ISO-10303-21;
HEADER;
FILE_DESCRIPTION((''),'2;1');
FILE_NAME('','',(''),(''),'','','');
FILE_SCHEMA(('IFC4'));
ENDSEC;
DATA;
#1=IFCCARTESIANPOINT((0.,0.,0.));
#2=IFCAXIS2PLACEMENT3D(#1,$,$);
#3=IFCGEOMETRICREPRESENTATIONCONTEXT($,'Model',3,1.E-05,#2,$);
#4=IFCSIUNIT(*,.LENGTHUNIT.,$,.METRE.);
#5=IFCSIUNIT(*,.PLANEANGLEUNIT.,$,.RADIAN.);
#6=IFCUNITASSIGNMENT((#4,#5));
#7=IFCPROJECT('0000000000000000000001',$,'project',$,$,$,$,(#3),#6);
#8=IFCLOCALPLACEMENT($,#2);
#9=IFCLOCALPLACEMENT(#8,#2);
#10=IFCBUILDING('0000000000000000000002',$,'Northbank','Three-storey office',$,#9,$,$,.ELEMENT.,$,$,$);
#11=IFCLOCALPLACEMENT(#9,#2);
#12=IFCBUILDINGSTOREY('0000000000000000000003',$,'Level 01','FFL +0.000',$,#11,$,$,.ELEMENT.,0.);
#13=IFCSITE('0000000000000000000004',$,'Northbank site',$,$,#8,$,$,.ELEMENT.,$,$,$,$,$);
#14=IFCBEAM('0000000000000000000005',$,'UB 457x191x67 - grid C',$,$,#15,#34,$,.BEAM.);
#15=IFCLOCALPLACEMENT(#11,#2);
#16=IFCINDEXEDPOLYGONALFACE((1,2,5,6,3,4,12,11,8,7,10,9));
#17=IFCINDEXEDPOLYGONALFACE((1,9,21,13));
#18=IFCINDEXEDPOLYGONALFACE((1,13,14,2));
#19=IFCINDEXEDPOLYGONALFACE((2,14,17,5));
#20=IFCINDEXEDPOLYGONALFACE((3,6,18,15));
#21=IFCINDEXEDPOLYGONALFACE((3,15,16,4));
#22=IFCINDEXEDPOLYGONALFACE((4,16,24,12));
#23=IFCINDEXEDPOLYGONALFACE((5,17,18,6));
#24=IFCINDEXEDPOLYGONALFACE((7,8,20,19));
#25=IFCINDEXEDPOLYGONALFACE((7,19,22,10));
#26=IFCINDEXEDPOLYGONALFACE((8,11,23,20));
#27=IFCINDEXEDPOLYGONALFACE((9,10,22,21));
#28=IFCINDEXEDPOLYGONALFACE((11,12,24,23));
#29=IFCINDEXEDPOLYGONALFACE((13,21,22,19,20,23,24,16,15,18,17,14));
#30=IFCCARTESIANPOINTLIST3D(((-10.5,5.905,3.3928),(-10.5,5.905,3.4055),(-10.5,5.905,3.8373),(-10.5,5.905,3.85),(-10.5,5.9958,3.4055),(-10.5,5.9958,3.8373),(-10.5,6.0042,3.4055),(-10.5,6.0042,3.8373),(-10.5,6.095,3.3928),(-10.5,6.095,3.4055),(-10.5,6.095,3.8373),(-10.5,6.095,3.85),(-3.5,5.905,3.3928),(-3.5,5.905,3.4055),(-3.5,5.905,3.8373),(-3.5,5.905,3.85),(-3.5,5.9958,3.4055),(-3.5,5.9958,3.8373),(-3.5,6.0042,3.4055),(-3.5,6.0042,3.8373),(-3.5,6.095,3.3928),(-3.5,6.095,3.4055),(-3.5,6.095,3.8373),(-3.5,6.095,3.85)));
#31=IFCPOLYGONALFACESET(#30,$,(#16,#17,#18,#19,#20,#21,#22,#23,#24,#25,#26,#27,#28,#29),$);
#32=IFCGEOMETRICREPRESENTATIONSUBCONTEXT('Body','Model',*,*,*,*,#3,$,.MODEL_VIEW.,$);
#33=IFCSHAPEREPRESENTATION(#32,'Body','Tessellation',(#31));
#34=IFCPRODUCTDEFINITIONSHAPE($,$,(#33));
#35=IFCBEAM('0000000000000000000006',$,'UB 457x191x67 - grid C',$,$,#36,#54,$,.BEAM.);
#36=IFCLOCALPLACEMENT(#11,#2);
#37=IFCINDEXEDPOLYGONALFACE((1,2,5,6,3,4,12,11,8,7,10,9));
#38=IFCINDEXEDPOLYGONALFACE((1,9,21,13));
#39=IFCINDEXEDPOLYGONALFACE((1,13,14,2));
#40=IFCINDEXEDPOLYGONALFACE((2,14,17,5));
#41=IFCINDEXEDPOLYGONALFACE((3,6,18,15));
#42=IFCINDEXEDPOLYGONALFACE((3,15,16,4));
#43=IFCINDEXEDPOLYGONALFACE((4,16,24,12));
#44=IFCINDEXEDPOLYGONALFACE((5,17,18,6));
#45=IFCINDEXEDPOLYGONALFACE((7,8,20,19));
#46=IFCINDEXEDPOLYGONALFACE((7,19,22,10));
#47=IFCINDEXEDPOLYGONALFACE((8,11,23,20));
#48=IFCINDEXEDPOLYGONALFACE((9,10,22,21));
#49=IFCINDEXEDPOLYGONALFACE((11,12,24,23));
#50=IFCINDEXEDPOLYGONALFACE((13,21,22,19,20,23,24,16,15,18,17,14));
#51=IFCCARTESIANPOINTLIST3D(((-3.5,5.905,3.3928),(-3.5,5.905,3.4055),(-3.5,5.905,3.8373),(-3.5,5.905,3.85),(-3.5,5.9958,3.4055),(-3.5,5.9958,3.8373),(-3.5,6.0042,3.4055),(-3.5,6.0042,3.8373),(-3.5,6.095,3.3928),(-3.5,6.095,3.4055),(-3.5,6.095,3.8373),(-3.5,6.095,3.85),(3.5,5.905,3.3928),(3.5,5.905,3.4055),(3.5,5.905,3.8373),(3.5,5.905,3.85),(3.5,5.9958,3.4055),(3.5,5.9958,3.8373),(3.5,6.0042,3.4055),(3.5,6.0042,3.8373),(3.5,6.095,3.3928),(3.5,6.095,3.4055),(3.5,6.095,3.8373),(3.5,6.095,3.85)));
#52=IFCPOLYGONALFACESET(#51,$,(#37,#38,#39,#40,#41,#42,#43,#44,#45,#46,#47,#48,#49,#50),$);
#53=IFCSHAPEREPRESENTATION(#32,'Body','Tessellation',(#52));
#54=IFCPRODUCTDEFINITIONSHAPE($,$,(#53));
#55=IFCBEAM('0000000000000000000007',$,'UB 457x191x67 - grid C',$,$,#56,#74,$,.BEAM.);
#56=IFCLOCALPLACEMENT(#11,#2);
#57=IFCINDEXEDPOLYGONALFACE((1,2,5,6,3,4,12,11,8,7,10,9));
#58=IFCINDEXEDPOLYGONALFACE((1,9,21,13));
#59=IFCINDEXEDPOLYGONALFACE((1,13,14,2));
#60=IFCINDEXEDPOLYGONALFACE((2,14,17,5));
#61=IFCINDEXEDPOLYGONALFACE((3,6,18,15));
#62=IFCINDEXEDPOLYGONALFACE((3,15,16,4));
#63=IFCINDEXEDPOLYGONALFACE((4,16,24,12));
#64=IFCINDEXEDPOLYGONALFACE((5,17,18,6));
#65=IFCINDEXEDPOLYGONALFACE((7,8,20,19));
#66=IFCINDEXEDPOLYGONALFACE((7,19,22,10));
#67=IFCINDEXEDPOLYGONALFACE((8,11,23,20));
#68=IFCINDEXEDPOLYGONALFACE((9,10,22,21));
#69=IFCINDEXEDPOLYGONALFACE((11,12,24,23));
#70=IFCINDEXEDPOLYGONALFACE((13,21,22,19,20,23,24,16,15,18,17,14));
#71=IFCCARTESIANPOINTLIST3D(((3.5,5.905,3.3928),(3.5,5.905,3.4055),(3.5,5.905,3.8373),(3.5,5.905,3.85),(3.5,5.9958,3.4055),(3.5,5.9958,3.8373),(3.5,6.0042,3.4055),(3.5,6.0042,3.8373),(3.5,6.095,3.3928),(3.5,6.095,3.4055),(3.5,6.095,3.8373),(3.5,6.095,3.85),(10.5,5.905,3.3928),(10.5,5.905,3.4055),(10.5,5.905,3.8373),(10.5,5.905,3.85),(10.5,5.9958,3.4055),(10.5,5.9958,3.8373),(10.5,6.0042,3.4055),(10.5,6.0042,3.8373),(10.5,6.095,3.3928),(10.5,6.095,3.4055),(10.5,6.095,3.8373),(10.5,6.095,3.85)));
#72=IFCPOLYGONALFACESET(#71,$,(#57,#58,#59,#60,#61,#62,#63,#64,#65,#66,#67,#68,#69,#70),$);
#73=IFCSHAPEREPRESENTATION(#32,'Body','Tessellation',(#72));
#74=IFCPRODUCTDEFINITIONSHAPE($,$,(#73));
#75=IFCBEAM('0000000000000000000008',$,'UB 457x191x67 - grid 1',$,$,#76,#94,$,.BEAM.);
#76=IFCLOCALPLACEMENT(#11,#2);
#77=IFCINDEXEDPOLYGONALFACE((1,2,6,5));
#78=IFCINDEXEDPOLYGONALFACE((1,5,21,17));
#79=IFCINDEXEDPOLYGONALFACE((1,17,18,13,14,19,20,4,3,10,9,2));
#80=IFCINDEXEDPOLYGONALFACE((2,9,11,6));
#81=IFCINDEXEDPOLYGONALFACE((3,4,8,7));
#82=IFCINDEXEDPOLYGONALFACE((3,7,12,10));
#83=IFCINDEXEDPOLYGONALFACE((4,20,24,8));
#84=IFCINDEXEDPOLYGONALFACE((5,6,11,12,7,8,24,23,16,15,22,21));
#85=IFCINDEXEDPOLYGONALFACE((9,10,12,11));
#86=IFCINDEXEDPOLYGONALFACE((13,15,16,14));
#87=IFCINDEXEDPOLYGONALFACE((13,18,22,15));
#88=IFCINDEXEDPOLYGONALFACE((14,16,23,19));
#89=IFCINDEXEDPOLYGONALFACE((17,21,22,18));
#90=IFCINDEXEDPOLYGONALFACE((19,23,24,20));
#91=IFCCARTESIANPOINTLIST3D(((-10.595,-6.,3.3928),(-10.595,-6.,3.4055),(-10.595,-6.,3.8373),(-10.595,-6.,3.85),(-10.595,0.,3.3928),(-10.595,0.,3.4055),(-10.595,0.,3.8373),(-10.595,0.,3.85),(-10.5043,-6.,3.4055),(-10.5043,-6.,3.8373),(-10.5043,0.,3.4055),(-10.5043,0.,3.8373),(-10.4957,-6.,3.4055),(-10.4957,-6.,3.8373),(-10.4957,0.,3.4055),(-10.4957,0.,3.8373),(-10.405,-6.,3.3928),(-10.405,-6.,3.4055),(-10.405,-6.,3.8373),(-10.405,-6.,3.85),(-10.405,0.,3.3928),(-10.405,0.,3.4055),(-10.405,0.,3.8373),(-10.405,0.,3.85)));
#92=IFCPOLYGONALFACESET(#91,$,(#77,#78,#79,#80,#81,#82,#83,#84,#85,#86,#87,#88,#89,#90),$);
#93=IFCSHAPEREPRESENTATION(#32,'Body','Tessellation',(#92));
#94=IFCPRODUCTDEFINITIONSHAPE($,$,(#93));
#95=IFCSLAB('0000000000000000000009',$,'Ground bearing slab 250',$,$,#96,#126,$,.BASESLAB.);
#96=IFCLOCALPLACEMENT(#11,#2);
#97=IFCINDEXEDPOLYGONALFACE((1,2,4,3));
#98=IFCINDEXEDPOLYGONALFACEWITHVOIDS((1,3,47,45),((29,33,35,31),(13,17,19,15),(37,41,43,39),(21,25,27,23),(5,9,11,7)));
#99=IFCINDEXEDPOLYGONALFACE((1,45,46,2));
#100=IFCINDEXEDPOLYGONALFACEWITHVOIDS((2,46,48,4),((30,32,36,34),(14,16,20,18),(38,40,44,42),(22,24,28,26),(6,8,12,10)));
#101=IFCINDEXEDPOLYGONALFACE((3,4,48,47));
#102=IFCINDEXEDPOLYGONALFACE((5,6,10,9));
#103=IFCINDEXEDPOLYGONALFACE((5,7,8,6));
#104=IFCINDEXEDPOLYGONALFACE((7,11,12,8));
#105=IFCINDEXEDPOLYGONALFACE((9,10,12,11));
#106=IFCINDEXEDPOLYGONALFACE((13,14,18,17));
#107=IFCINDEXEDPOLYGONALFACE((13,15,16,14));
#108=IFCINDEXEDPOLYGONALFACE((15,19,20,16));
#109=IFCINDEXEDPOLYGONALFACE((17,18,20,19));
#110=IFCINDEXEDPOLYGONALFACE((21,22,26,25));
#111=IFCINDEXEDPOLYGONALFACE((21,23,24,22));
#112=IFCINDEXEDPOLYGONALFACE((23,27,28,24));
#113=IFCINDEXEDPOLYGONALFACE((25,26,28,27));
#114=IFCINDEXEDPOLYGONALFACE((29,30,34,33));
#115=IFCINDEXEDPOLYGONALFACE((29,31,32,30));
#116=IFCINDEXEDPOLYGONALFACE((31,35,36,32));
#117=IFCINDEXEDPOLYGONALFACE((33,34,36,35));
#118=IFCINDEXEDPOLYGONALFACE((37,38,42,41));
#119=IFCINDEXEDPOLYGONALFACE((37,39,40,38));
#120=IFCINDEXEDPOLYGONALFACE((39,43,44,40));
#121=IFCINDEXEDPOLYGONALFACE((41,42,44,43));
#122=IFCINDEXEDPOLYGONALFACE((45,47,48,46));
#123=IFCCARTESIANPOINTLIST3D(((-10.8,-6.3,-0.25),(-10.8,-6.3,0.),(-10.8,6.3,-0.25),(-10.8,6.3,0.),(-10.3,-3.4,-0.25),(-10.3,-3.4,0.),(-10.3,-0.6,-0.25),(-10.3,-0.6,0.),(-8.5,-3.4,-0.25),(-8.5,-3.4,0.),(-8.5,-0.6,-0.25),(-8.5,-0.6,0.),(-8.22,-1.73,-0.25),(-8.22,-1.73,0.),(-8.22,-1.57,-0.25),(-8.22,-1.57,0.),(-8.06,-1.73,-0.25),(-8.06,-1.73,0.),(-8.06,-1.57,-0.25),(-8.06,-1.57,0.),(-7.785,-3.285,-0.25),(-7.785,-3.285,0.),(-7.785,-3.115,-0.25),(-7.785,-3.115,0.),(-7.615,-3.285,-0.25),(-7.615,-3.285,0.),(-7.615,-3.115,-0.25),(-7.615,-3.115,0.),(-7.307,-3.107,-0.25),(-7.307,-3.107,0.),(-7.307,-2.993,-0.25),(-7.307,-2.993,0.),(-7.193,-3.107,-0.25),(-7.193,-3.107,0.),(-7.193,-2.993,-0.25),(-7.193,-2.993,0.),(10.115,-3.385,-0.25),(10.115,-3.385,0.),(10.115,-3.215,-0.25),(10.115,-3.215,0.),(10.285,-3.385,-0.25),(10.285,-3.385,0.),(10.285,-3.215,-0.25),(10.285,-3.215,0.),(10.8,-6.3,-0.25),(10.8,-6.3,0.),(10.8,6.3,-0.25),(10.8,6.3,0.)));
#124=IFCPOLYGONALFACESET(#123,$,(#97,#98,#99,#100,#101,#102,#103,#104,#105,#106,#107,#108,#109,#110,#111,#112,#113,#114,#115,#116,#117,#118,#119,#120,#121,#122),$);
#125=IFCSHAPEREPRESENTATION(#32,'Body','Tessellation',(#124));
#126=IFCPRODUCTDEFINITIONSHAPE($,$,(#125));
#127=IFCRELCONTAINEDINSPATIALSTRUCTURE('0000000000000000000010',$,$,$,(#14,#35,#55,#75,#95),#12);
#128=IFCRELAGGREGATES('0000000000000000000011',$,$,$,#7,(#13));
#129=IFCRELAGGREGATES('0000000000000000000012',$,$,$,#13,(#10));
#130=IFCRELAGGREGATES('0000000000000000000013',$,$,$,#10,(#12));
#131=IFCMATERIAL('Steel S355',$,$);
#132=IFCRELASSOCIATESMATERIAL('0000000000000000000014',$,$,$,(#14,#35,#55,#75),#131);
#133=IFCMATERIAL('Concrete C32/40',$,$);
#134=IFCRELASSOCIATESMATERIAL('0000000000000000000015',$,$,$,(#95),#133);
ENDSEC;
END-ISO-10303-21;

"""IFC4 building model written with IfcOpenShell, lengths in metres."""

from ifc_helpers import new_model, si_unit, frame, origin, place, context, subcontext, project, spatial, polyline, i_section, outline, extrude, material, element, save


model = new_model("IFC4")

# Units and contexts
model_context = context("Model", 3, precision=1e-05, world=origin())
body_context = subcontext(model_context, "Body", "Model", "MODEL_VIEW")
ifc_project = project(units=[si_unit("LENGTHUNIT", "METRE"), si_unit("PLANEANGLEUNIT", "RADIAN")], contexts=[model_context])

# Site, building, storey
site_placement = place(None, origin())
site = spatial("IfcSite", under=ifc_project, at=site_placement, Name="Northbank site", CompositionType="ELEMENT")
building_placement = place(site_placement, origin())
building = spatial("IfcBuilding", under=site, at=building_placement, Name="Northbank", Description="Three-storey office", CompositionType="ELEMENT")
storey_placement = place(building_placement, origin())
storey = spatial("IfcBuildingStorey", under=building, at=storey_placement, Name="Level 01", Description="FFL +0.000", CompositionType="ELEMENT", Elevation=0.0)

# Shared definitions
ifc_material_1 = material(Name="Steel S355")

# Beams
beam_1_placement = place(storey_placement, origin())
element("IfcBeam", 1, at=beam_1_placement, inside=storey, material=ifc_material_1, Name="UB 457x191x67 - grid C", PredefinedType="BEAM", context=body_context, shape_type="SweptSolid", body=[
    extrude(i_section(OverallWidth=0.1899, OverallDepth=0.4572, WebThickness=0.0085, FlangeThickness=0.0127), frame((-10.5, 6.0, 3.6214), z_axis=(1.0, 0.0, 0.0), x_axis=(0.0, 1.0, 0.0)), (0.0, 0.0, 1.0), 7.0),
])
beam_2_placement = place(storey_placement, origin())
element("IfcBeam", 2, at=beam_2_placement, inside=storey, material=ifc_material_1, Name="UB 457x191x67 - grid C", PredefinedType="BEAM", context=body_context, shape_type="SweptSolid", body=[
    extrude(i_section(OverallWidth=0.1899, OverallDepth=0.4572, WebThickness=0.0085, FlangeThickness=0.0127), frame((-3.5, 6.0, 3.6214), z_axis=(1.0, 0.0, 0.0), x_axis=(0.0, 1.0, 0.0)), (0.0, 0.0, 1.0), 7.0),
])
beam_3_placement = place(storey_placement, origin())
element("IfcBeam", 3, at=beam_3_placement, inside=storey, material=ifc_material_1, Name="UB 457x191x67 - grid C", PredefinedType="BEAM", context=body_context, shape_type="SweptSolid", body=[
    extrude(i_section(OverallWidth=0.1899, OverallDepth=0.4572, WebThickness=0.0085, FlangeThickness=0.0127), frame((3.5, 6.0, 3.6214), z_axis=(1.0, 0.0, 0.0), x_axis=(0.0, 1.0, 0.0)), (0.0, 0.0, 1.0), 7.0),
])
beam_4_placement = place(storey_placement, origin())
element("IfcBeam", 4, at=beam_4_placement, inside=storey, material=ifc_material_1, Name="UB 457x191x67 - grid 1", PredefinedType="BEAM", context=body_context, shape_type="SweptSolid", body=[
    extrude(i_section(OverallWidth=0.1899, OverallDepth=0.4572, WebThickness=0.0085, FlangeThickness=0.0127), frame((-10.5, -6.0, 3.6214), z_axis=(0.0, 1.0, 0.0), x_axis=(-1.0, 0.0, 0.0)), (0.0, 0.0, 1.0), 6.0),
])

# Slab
ifc_material_2 = material(Name="Concrete C32/40")
slab_placement = place(storey_placement, origin())
element("IfcSlab", 5, at=slab_placement, inside=storey, material=ifc_material_2, Name="Ground bearing slab 250", PredefinedType="BASESLAB", context=body_context, shape_type="SweptSolid", body=[
    extrude(outline(polyline([(-10.8, -6.3), (10.8, -6.3), (10.8, 6.3), (-10.8, 6.3), (-10.8, -6.3)]), holes=[polyline([(-10.3, -3.4), (-10.3, -0.6), (-8.5, -0.6), (-8.5, -3.4), (-10.3, -3.4)]), polyline([(-7.307, -3.107), (-7.307, -2.993), (-7.193, -2.993), (-7.193, -3.107), (-7.307, -3.107)]), polyline([(-7.785, -3.285), (-7.785, -3.115), (-7.615, -3.115), (-7.615, -3.285), (-7.785, -3.285)]), polyline([(10.115, -3.385), (10.115, -3.215), (10.285, -3.215), (10.285, -3.385), (10.115, -3.385)]), polyline([(-8.22, -1.73), (-8.22, -1.57), (-8.06, -1.57), (-8.06, -1.73), (-8.22, -1.73)])]), frame((0.0, 0.0, -0.25)), (0.0, 0.0, 1.0), 0.25),
])

save(model, "model.ifc")
